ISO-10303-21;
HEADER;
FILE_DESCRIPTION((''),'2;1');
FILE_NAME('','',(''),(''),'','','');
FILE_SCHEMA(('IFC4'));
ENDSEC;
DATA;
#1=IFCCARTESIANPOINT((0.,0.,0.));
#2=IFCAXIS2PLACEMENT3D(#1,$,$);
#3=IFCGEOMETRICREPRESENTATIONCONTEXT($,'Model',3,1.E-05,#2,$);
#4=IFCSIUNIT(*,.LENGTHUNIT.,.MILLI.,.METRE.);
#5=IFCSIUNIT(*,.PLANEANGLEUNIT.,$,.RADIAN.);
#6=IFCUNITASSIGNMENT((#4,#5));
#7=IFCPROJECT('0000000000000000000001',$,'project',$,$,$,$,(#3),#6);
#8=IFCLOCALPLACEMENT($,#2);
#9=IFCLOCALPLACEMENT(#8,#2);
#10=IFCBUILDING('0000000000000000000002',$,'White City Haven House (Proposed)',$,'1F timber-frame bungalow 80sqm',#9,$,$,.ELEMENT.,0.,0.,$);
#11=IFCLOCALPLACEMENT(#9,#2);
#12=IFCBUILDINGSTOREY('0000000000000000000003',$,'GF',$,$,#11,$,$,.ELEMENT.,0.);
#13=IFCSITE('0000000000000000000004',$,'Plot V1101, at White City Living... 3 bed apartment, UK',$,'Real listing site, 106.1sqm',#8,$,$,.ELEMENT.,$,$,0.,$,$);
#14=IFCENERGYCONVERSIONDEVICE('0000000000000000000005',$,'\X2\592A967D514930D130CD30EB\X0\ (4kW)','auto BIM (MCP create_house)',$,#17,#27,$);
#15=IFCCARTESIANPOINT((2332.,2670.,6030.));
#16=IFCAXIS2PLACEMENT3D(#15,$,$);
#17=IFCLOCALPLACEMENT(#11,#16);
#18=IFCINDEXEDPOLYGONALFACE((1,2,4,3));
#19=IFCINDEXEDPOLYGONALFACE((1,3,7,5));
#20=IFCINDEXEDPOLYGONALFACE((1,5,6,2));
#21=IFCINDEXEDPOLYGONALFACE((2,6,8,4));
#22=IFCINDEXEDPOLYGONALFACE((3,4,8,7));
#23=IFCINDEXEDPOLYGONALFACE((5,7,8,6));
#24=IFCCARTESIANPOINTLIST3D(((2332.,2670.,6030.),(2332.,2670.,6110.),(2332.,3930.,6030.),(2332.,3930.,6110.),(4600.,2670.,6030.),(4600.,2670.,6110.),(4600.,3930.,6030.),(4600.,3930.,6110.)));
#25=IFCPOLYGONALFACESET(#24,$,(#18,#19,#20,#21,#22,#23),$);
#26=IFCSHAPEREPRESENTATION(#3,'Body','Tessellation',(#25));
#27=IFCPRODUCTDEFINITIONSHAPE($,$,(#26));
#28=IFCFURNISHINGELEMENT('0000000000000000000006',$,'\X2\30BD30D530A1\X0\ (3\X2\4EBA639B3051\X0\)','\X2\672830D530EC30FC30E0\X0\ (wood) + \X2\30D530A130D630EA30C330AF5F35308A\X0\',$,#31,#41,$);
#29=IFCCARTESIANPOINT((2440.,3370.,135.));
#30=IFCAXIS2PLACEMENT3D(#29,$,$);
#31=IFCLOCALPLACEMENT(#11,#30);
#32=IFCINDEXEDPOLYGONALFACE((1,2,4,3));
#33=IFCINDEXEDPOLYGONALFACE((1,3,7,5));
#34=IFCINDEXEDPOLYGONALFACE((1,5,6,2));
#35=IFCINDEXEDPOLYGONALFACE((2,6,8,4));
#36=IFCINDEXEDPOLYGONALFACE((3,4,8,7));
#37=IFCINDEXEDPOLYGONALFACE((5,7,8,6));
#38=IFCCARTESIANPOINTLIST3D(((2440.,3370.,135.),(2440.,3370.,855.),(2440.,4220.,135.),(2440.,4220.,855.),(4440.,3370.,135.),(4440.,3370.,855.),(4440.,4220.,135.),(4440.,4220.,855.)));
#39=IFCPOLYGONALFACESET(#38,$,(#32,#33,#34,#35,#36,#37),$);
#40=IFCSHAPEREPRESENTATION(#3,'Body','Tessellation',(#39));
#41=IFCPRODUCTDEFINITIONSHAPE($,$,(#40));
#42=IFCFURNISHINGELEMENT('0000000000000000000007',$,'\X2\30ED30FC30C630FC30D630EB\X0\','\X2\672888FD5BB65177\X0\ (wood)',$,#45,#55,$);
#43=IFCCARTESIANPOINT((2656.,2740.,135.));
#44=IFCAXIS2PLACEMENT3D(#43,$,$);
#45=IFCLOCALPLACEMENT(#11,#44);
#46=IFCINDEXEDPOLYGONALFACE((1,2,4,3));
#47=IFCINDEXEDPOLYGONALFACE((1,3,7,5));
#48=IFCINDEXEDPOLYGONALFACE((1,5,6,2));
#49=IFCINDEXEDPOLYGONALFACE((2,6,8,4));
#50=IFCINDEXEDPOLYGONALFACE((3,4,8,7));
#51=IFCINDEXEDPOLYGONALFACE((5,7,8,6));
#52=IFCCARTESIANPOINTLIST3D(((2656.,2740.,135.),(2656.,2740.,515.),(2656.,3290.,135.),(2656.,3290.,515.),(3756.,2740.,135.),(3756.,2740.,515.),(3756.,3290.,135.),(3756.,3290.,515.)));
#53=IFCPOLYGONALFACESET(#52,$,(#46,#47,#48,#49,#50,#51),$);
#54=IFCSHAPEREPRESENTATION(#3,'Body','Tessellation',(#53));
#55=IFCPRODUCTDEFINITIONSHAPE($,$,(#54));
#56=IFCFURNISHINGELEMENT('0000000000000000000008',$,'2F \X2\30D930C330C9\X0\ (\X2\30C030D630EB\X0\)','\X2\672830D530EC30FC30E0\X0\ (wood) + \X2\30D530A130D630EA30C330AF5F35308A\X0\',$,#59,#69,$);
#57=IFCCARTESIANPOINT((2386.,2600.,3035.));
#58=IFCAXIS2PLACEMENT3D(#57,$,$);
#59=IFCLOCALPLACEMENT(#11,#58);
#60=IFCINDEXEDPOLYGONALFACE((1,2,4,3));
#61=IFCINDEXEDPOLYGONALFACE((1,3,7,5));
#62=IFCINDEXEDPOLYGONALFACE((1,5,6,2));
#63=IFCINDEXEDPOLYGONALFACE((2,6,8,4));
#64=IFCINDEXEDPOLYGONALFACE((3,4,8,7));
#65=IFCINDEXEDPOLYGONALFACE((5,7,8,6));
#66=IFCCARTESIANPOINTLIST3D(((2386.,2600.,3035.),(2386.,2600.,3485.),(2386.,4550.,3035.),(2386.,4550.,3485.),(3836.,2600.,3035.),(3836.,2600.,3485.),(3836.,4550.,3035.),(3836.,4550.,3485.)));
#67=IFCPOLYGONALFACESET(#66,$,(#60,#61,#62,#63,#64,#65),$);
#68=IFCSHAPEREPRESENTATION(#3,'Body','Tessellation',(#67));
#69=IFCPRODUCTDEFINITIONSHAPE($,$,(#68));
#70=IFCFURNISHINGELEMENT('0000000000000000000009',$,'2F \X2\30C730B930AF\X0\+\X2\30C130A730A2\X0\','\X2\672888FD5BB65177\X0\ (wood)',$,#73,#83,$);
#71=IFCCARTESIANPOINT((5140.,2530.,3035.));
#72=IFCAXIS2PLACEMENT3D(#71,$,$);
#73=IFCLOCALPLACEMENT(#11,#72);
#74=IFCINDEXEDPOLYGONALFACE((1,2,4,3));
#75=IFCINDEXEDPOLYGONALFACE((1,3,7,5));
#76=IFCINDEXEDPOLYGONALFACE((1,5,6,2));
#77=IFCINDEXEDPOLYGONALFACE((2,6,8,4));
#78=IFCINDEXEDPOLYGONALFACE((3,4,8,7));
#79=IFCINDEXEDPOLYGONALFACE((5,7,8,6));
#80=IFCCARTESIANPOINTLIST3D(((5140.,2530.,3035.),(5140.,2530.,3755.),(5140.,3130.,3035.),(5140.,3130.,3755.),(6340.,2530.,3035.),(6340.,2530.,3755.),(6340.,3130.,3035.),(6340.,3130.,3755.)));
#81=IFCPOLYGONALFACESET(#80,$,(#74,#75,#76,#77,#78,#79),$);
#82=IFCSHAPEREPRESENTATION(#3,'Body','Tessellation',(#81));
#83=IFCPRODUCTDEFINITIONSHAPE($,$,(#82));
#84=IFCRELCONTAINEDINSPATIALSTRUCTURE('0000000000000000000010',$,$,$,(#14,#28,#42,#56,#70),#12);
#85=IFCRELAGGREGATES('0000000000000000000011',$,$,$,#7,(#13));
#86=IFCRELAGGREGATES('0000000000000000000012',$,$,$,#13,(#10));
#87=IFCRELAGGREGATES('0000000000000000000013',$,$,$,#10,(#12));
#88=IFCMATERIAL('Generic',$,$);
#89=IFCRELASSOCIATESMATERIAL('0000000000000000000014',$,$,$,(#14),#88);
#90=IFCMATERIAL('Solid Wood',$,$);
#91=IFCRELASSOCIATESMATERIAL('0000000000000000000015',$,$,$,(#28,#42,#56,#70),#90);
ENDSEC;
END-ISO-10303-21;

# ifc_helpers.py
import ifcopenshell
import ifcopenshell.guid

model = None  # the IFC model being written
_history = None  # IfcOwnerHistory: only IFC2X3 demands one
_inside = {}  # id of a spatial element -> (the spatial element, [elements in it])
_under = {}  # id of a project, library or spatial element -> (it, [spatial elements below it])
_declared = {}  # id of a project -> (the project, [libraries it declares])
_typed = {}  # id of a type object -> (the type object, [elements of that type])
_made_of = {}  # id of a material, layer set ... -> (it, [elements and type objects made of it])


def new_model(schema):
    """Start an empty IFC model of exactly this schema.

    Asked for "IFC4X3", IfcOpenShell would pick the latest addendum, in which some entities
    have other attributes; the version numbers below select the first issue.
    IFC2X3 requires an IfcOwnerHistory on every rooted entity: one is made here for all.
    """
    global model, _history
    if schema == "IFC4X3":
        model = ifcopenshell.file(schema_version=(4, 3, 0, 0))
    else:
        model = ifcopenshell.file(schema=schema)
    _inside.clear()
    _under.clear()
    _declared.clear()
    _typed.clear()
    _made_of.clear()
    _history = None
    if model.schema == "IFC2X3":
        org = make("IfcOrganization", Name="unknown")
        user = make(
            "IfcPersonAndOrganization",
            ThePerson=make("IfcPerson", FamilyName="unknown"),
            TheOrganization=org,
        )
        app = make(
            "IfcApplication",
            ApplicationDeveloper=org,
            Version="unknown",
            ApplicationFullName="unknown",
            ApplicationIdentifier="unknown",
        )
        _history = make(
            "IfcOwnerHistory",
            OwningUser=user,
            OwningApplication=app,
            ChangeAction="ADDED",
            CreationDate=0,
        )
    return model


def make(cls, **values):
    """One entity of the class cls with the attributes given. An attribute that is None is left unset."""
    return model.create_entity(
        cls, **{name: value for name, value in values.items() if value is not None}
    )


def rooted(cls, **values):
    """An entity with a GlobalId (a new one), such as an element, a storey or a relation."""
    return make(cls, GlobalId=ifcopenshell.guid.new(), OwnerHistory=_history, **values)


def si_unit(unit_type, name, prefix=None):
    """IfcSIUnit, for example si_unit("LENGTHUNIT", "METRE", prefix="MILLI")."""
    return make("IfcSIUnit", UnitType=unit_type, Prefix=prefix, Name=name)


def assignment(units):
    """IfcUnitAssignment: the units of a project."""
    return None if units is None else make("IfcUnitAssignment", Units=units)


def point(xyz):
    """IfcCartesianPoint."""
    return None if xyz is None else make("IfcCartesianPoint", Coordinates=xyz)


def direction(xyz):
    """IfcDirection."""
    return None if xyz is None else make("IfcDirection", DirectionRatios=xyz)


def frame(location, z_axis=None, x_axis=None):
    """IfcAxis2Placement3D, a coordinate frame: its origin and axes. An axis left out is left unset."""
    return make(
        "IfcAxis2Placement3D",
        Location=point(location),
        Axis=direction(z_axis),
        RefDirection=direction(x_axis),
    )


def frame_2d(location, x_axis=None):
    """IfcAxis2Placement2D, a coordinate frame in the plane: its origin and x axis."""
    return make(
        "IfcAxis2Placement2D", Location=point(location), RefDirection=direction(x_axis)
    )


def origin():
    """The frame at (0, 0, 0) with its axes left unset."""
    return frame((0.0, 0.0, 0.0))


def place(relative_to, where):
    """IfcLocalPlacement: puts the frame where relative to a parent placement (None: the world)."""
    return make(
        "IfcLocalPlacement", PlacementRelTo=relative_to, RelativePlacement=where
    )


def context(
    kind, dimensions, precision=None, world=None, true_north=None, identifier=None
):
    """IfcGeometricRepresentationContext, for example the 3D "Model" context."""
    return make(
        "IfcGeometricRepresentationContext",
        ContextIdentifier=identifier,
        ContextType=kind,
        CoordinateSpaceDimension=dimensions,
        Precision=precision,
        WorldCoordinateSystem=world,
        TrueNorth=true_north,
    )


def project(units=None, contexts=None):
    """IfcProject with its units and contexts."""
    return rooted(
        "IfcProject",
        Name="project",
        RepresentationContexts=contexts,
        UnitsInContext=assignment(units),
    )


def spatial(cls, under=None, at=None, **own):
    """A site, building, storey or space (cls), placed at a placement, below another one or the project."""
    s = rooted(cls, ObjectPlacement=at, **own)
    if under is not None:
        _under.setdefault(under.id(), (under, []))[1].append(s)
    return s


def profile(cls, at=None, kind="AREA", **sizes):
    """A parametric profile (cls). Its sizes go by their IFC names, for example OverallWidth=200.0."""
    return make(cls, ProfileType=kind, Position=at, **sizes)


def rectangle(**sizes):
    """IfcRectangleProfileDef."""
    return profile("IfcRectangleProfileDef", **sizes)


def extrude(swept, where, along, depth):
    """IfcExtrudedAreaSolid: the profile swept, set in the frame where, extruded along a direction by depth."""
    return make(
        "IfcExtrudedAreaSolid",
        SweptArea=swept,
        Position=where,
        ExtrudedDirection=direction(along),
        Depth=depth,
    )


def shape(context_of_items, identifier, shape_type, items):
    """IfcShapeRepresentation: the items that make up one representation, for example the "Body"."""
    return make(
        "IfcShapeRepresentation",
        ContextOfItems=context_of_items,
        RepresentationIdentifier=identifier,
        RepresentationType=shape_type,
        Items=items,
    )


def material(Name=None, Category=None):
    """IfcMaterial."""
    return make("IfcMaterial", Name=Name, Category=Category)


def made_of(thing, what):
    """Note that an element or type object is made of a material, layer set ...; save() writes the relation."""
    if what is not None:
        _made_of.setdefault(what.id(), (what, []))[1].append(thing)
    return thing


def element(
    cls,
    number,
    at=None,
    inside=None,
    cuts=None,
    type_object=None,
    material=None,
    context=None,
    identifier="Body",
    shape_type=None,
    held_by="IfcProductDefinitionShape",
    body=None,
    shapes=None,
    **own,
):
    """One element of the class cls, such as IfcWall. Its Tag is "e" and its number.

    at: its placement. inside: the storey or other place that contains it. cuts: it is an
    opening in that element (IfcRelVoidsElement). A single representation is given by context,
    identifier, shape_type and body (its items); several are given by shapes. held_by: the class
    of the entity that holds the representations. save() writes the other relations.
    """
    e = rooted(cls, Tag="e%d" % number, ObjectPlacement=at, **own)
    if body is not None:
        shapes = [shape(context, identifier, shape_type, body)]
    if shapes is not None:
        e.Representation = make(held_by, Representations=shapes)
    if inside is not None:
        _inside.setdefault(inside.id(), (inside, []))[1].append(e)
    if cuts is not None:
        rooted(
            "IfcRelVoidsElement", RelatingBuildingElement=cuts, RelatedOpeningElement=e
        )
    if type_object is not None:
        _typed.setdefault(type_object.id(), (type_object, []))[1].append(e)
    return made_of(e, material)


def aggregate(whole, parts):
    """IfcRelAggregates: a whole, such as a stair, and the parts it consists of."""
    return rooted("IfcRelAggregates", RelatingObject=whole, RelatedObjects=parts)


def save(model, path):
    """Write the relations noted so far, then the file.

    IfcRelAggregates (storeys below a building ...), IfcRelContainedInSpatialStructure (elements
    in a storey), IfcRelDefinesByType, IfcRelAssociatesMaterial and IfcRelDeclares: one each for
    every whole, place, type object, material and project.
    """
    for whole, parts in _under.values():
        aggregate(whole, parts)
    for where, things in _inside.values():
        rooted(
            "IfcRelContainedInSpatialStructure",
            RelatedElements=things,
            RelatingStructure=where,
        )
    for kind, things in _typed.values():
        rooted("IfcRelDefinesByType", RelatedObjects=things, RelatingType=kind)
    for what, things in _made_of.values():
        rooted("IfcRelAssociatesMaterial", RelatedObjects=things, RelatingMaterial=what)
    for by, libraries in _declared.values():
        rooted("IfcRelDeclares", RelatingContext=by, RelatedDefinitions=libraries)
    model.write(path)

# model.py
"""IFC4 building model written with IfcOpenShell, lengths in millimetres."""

from ifc_helpers import new_model, si_unit, frame, frame_2d, origin, place, context, project, spatial, rectangle, extrude, material, element, save


model = new_model("IFC4")

# Units and contexts
model_context = context("Model", 3, precision=1e-05, world=origin())
ifc_project = project(units=[si_unit("LENGTHUNIT", "METRE", prefix="MILLI"), si_unit("PLANEANGLEUNIT", "RADIAN")], contexts=[model_context])

# Site, building, storey
site_placement = place(None, origin())
site = spatial("IfcSite", under=ifc_project, at=site_placement, Name="Plot V1101, at White City Living... 3 bed apartment, UK", ObjectType="Real listing site, 106.1sqm", CompositionType="ELEMENT", RefElevation=0.0)
building_placement = place(site_placement, origin())
building = spatial("IfcBuilding", under=site, at=building_placement, Name="White City Haven House (Proposed)", ObjectType="1F timber-frame bungalow 80sqm", CompositionType="ELEMENT", ElevationOfRefHeight=0.0, ElevationOfTerrain=0.0)
storey_placement = place(building_placement, origin())
storey = spatial("IfcBuildingStorey", under=building, at=storey_placement, Name="GF", CompositionType="ELEMENT", Elevation=0.0)

# Shared definitions
ifc_material_1 = material(Name="Solid Wood")

# Shared definitions
ifc_material_2 = material(Name="Generic")

# Energy conversion device
energy_conversion_device_placement = place(storey_placement, frame((2332.0, 2670.0, 6030.0)))
element("IfcEnergyConversionDevice", 1, at=energy_conversion_device_placement, inside=storey, material=ifc_material_2, Name="太陽光パネル (4kW)", Description="auto BIM (MCP create_house)", context=model_context, shape_type="SweptSolid", body=[
    extrude(rectangle(XDim=2268.0, YDim=1260.0, at=frame_2d((1134.0, 630.0))), frame((2332.0, 2670.0, 6030.0)), (0.0, 0.0, 1.0), 80.0),
])

# Furnishing elements
furnishing_1_placement = place(storey_placement, frame((2440.0, 3370.0, 135.0)))
element("IfcFurnishingElement", 2, at=furnishing_1_placement, inside=storey, material=ifc_material_1, Name="ソファ (3人掛け)", Description="木フレーム (wood) + ファブリック張り", context=model_context, shape_type="SweptSolid", body=[
    extrude(rectangle(XDim=2000.0, YDim=850.0, at=frame_2d((1000.0, 425.0))), frame((2440.0, 3370.0, 135.0)), (0.0, 0.0, 1.0), 720.0),
])
furnishing_2_placement = place(storey_placement, frame((2656.0, 2740.0, 135.0)))
element("IfcFurnishingElement", 3, at=furnishing_2_placement, inside=storey, material=ifc_material_1, Name="ローテーブル", Description="木製家具 (wood)", context=model_context, shape_type="SweptSolid", body=[
    extrude(rectangle(XDim=1100.0, YDim=550.0, at=frame_2d((550.0, 275.0))), frame((2656.0, 2740.0, 135.0)), (0.0, 0.0, 1.0), 380.0),
])
furnishing_3_placement = place(storey_placement, frame((2386.0, 2600.0, 3035.0)))
element("IfcFurnishingElement", 4, at=furnishing_3_placement, inside=storey, material=ifc_material_1, Name="2F ベッド (ダブル)", Description="木フレーム (wood) + ファブリック張り", context=model_context, shape_type="SweptSolid", body=[
    extrude(rectangle(XDim=1450.0, YDim=1950.0, at=frame_2d((725.0, 975.0))), frame((2386.0, 2600.0, 3035.0)), (0.0, 0.0, 1.0), 450.0),
])
furnishing_4_placement = place(storey_placement, frame((5140.0, 2530.0, 3035.0)))
element("IfcFurnishingElement", 5, at=furnishing_4_placement, inside=storey, material=ifc_material_1, Name="2F デスク+チェア", Description="木製家具 (wood)", context=model_context, shape_type="SweptSolid", body=[
    extrude(rectangle(XDim=1200.0, YDim=600.0, at=frame_2d((600.0, 300.0))), frame((5140.0, 2530.0, 3035.0)), (0.0, 0.0, 1.0), 720.0),
])

save(model, "model.ifc")
